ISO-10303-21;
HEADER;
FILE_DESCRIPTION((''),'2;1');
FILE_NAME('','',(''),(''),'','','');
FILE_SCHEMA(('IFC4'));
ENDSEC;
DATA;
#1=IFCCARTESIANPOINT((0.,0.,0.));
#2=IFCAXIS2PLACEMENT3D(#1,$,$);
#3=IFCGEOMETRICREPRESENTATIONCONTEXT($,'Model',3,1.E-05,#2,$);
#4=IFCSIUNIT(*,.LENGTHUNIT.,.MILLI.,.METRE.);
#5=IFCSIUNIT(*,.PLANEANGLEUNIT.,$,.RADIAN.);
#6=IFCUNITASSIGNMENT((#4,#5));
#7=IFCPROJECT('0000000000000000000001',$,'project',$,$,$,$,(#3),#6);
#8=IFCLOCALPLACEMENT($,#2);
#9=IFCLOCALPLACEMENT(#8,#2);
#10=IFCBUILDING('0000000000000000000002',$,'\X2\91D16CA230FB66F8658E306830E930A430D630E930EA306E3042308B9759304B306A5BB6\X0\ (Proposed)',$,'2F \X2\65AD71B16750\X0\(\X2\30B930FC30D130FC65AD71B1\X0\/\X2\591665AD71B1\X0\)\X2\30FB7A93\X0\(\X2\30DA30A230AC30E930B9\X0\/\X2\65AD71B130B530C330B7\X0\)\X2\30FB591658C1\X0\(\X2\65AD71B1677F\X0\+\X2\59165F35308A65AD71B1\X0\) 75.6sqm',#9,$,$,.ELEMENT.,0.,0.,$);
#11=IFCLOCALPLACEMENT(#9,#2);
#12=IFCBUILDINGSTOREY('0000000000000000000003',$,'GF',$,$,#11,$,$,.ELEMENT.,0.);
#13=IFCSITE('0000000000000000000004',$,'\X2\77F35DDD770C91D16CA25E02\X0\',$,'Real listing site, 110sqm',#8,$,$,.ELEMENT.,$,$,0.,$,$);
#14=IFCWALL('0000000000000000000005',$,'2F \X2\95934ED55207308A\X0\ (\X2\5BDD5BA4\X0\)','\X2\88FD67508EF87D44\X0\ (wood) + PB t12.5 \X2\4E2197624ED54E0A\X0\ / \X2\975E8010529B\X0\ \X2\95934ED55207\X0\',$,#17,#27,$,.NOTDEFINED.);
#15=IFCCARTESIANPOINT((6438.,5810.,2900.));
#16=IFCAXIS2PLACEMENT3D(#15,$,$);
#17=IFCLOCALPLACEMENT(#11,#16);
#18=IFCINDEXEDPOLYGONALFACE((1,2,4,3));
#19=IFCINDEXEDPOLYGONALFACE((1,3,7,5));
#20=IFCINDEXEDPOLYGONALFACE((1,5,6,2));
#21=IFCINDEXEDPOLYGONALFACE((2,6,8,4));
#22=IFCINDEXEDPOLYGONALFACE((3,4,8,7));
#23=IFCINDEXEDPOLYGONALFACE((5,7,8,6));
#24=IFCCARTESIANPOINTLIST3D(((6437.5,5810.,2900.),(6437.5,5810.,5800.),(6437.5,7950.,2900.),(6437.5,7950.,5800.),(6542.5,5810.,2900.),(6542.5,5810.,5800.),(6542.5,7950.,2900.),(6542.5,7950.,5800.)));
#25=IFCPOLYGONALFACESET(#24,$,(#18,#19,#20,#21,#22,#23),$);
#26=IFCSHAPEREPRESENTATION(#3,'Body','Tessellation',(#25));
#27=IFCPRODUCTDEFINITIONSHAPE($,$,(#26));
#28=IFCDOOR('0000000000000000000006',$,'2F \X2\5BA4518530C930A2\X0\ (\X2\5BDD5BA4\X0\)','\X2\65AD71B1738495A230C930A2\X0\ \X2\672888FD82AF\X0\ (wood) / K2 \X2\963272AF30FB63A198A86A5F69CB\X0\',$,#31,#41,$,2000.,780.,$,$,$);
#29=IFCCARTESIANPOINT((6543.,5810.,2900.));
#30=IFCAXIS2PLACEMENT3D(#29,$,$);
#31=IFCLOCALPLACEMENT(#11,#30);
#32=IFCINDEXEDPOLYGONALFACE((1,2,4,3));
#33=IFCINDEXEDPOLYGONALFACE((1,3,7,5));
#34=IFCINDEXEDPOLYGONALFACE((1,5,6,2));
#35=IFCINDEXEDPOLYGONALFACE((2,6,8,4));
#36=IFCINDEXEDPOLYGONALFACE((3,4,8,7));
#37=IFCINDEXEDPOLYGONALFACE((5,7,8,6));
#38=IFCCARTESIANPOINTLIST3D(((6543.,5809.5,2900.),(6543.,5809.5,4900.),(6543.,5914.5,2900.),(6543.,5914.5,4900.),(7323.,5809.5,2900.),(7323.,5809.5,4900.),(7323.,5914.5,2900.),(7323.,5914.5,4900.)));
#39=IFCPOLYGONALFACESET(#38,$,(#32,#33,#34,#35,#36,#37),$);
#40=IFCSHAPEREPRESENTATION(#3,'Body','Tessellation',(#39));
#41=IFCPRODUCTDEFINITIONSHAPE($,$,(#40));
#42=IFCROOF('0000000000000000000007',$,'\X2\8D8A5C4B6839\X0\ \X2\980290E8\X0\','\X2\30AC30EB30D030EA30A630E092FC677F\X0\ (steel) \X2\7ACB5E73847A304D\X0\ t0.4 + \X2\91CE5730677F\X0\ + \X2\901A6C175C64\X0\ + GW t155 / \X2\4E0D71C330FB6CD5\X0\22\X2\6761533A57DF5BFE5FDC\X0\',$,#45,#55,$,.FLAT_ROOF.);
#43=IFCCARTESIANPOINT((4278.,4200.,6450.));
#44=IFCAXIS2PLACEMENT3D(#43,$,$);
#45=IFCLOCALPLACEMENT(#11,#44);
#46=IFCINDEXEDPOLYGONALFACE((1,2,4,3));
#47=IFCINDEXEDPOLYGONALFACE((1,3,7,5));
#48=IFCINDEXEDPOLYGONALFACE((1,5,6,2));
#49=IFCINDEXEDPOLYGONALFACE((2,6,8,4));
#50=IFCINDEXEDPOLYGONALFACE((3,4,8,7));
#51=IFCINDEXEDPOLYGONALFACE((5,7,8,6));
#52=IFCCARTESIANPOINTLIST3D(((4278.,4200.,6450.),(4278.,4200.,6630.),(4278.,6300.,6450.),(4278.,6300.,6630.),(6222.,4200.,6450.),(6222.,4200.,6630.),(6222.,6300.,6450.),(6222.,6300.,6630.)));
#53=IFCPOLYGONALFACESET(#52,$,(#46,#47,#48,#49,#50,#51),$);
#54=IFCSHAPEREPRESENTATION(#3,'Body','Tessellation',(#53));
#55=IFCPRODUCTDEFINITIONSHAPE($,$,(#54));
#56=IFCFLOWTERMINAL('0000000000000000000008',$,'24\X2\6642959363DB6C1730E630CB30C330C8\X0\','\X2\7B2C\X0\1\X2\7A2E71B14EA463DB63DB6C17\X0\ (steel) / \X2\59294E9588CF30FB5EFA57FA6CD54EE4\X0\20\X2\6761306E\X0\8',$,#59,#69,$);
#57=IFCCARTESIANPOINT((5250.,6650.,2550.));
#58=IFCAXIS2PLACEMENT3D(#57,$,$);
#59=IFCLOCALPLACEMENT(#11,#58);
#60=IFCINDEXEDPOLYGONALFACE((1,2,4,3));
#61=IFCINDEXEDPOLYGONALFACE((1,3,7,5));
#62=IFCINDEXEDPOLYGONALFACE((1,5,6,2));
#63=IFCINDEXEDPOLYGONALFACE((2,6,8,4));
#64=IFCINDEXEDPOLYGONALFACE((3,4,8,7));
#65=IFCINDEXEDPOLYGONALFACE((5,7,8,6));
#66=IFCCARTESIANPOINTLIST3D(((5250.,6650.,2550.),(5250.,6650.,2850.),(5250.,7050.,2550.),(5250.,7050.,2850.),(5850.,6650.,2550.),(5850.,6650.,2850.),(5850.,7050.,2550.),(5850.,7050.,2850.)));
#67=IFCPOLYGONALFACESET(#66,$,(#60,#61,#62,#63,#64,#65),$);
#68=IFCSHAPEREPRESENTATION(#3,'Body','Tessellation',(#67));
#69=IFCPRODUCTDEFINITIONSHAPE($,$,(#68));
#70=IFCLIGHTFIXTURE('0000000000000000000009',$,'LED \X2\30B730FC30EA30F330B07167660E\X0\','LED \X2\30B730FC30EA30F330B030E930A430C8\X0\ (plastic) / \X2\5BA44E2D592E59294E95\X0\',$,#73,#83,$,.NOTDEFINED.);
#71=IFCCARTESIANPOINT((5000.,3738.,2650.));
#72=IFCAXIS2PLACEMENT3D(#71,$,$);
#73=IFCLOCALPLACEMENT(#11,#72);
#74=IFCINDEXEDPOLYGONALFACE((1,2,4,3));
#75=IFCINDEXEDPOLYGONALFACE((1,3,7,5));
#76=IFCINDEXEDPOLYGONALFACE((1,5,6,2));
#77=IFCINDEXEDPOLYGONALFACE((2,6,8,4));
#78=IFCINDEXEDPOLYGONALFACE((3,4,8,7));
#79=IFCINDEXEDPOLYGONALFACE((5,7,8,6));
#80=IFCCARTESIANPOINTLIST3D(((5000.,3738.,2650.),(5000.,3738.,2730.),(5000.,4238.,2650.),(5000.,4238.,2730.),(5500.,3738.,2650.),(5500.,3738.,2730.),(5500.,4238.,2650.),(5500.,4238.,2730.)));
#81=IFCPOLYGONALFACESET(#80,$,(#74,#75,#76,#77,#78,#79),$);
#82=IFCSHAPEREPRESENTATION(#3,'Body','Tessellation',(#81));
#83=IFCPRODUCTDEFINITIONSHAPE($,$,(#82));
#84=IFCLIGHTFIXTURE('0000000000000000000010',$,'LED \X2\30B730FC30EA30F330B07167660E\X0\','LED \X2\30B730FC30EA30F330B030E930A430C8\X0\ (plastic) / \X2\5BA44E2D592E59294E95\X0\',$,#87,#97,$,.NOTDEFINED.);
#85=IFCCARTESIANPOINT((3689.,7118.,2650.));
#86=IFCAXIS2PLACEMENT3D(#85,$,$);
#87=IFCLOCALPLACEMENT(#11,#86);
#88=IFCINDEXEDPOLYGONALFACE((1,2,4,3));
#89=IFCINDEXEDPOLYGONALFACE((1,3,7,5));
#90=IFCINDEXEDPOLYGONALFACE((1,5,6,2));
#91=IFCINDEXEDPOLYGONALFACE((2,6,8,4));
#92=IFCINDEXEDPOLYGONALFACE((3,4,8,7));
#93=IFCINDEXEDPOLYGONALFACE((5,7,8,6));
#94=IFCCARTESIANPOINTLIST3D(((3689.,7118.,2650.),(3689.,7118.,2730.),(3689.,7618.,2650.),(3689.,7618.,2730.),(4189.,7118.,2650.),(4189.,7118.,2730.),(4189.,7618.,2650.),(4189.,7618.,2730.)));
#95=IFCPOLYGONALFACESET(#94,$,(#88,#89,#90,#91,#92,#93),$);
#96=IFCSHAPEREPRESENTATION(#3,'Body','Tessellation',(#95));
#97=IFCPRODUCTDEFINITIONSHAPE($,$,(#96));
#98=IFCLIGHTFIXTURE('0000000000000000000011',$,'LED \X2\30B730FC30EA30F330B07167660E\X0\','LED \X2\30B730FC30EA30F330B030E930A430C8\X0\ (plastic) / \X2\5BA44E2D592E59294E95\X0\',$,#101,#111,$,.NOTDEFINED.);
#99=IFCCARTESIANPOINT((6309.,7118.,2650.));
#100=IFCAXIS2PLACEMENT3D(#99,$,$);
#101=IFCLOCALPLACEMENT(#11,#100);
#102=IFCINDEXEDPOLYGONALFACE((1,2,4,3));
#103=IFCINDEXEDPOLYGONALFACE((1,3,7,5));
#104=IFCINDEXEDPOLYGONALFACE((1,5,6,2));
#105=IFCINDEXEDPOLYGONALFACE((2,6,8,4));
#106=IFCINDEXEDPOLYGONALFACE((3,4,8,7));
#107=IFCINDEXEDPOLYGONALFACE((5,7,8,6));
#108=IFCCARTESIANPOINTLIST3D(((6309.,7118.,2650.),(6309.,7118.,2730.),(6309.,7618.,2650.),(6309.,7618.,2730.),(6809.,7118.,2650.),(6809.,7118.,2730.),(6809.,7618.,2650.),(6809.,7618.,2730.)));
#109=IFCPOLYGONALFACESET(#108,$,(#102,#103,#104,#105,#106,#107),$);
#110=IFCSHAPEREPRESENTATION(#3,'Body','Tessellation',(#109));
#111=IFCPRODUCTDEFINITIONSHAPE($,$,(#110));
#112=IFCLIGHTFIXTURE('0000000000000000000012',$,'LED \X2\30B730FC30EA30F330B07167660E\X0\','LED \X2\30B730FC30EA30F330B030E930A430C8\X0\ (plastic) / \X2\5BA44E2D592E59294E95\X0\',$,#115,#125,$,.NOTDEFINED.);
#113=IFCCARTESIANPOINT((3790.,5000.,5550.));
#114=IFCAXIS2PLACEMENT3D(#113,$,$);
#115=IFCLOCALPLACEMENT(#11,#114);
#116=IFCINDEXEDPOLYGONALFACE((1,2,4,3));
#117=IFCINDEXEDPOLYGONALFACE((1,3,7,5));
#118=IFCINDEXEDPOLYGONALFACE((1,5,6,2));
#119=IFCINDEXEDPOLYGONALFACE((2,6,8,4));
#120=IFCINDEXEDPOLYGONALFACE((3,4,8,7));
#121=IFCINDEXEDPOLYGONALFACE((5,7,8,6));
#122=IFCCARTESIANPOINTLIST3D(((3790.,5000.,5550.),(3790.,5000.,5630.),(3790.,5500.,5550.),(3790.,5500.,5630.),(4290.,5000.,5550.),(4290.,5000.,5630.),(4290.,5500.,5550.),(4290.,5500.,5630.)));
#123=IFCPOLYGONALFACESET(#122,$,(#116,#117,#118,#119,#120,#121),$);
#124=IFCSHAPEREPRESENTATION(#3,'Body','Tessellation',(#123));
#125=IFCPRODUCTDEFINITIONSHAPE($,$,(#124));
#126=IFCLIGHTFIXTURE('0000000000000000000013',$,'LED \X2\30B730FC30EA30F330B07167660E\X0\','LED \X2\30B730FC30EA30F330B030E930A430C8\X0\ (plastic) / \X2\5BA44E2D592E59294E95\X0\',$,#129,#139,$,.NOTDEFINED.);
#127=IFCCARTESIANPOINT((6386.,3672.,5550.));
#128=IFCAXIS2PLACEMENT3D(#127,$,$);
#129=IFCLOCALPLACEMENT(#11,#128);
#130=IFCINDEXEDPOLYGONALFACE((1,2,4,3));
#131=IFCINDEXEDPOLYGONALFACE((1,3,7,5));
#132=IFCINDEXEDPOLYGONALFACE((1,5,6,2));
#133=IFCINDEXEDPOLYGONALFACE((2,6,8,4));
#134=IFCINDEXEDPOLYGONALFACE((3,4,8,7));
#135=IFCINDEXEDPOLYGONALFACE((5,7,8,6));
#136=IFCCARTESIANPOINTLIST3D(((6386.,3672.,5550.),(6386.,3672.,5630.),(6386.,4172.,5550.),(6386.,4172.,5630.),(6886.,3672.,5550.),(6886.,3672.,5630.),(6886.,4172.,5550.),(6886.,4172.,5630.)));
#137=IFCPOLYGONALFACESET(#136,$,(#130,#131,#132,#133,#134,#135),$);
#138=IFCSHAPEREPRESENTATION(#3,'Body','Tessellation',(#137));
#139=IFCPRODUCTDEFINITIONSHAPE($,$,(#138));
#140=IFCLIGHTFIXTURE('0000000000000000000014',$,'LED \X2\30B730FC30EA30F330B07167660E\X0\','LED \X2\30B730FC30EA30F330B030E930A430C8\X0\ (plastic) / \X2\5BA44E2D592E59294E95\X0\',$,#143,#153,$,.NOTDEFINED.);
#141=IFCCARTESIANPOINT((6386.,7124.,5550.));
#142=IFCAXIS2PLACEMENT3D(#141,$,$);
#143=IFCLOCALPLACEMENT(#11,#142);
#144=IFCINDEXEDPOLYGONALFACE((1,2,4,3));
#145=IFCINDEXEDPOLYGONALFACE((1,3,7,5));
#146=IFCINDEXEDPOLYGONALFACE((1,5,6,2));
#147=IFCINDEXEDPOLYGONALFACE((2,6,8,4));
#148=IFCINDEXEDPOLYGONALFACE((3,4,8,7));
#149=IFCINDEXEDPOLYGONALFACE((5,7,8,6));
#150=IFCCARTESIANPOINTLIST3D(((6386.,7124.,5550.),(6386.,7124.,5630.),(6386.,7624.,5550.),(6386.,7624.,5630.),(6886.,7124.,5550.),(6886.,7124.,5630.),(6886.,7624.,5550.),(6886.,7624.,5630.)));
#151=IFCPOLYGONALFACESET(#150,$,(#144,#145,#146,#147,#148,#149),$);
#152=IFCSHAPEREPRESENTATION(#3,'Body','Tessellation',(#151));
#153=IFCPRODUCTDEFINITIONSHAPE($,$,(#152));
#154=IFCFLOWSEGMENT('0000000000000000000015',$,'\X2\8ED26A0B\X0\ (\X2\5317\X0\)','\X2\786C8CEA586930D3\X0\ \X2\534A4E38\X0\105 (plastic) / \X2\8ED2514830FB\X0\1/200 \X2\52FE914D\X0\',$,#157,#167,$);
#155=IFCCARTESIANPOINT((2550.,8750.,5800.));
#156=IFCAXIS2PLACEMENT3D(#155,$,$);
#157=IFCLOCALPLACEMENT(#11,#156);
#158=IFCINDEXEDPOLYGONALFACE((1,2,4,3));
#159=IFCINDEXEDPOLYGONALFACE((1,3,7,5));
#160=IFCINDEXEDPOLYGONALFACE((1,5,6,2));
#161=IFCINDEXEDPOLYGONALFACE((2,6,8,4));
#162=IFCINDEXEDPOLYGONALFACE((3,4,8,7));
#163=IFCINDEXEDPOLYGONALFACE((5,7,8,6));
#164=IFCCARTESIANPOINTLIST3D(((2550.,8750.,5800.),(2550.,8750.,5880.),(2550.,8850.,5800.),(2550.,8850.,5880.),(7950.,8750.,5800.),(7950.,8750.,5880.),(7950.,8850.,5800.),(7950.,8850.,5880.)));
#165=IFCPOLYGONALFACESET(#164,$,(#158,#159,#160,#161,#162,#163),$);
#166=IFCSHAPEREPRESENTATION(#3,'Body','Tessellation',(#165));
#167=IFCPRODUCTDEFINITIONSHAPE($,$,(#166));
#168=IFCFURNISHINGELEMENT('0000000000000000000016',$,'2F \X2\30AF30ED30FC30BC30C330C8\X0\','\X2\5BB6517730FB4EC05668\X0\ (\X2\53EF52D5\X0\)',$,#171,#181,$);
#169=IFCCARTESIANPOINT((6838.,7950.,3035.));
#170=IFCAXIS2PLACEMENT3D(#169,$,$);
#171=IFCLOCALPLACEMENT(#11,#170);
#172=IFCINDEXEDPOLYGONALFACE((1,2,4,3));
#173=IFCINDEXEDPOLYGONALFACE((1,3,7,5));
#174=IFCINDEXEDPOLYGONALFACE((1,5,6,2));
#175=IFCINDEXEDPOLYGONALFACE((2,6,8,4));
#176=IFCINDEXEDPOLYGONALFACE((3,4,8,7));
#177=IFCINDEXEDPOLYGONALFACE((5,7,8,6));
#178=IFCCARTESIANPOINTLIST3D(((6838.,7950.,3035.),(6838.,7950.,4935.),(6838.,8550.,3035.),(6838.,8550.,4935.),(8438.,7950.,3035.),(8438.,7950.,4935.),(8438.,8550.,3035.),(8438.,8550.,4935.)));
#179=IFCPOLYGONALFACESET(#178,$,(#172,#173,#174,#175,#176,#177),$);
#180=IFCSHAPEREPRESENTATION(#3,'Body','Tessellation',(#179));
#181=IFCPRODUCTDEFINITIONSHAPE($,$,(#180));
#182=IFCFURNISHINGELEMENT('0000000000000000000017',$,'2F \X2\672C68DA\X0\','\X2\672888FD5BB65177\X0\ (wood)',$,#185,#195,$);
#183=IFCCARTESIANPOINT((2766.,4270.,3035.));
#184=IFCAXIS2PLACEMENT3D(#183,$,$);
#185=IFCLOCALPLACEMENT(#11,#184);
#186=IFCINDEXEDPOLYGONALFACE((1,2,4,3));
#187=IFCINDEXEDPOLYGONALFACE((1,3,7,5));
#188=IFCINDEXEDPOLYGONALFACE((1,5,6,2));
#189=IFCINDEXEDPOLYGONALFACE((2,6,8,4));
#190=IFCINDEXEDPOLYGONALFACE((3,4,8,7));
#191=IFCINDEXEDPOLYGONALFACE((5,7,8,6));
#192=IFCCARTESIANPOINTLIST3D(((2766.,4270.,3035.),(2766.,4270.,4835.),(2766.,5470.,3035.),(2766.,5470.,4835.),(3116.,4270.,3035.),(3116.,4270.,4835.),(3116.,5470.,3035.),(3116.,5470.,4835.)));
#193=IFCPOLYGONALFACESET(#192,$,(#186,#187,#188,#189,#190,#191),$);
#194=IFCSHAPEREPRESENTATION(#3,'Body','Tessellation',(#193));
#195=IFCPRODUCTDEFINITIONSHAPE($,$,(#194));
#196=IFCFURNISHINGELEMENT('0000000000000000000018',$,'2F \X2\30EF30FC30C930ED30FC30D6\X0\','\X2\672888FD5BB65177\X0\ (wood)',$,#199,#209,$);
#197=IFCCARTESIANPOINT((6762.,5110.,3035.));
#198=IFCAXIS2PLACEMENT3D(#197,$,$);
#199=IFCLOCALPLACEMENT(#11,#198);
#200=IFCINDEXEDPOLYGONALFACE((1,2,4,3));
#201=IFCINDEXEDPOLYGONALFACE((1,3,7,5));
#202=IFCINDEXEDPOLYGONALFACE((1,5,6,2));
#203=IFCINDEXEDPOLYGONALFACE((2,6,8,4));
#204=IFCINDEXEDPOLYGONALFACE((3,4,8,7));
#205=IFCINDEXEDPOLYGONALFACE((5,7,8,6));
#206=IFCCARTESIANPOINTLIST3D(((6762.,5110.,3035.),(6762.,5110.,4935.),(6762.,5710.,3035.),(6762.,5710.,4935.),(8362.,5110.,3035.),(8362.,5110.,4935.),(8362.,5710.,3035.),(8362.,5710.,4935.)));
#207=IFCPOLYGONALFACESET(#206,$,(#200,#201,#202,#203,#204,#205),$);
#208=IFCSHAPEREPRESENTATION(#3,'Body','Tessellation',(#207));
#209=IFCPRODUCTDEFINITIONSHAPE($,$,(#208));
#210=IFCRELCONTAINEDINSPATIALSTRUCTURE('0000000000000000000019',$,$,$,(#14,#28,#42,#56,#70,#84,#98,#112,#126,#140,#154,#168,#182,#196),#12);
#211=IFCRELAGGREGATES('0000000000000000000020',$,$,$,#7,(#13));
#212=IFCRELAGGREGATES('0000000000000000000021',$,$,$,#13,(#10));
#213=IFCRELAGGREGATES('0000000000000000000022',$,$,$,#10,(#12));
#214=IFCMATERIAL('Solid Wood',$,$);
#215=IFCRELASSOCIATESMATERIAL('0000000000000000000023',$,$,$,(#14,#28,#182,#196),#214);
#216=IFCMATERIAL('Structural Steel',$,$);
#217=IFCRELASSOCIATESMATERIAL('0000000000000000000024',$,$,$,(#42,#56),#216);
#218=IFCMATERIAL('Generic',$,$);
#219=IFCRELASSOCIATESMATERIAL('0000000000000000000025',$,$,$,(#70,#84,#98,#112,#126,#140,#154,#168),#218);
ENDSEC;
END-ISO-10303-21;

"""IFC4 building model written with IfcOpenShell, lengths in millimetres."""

from ifc_helpers import new_model, si_unit, frame, frame_2d, origin, place, context, project, spatial, rectangle, extrude, material, element, save


model = new_model("IFC4")

# Units and contexts
model_context = context("Model", 3, precision=1e-05, world=origin())
ifc_project = project(units=[si_unit("LENGTHUNIT", "METRE", prefix="MILLI"), si_unit("PLANEANGLEUNIT", "RADIAN")], contexts=[model_context])

# Site, building, storey
site_placement = place(None, origin())
site = spatial("IfcSite", under=ifc_project, at=site_placement, Name="石川県金沢市", ObjectType="Real listing site, 110sqm", CompositionType="ELEMENT", RefElevation=0.0)
building_placement = place(site_placement, origin())
building = spatial("IfcBuilding", under=site, at=building_placement, Name="金沢・書斎とライブラリのある静かな家 (Proposed)", ObjectType="2F 断熱材(スーパー断熱/外断熱)・窓(ペアガラス/断熱サッシ)・外壁(断熱板+外張り断熱) 75.6sqm", CompositionType="ELEMENT", ElevationOfRefHeight=0.0, ElevationOfTerrain=0.0)
storey_placement = place(building_placement, origin())
storey = spatial("IfcBuildingStorey", under=building, at=storey_placement, Name="GF", CompositionType="ELEMENT", Elevation=0.0)

# Shared definitions
ifc_material_1 = material(Name="Solid Wood")

# Wall
wall_1_placement = place(storey_placement, frame((6438.0, 5810.0, 2900.0)))
element("IfcWall", 1, at=wall_1_placement, inside=storey, material=ifc_material_1, Name="2F 間仕切り (寝室)", Description="製材軸組 (wood) + PB t12.5 両面仕上 / 非耐力 間仕切", PredefinedType="NOTDEFINED", context=model_context, shape_type="SweptSolid", body=[
    extrude(rectangle(XDim=105.0, YDim=2140.0, at=frame_2d((52.0, 1070.0))), frame((6438.0, 5810.0, 2900.0)), (0.0, 0.0, 1.0), 2900.0),
])

# Door
door_placement = place(storey_placement, frame((6543.0, 5810.0, 2900.0)))
element("IfcDoor", 2, at=door_placement, inside=storey, material=ifc_material_1, Name="2F 室内ドア (寝室)", Description="断熱玄関ドア 木製芯 (wood) / K2 防犯・採風機構", OverallHeight=2000.0, OverallWidth=780.0, context=model_context, shape_type="SweptSolid", body=[
    extrude(rectangle(XDim=780.0, YDim=105.0, at=frame_2d((390.0, 52.0))), frame((6543.0, 5810.0, 2900.0)), (0.0, 0.0, 1.0), 2000.0),
])

# Roof
ifc_material_2 = material(Name="Structural Steel")
roof_placement = place(storey_placement, frame((4278.0, 4200.0, 6450.0)))
element("IfcRoof", 3, at=roof_placement, inside=storey, material=ifc_material_2, Name="越屋根 頂部", Description="ガルバリウム鋼板 (steel) 立平葺き t0.4 + 野地板 + 通気層 + GW t155 / 不燃・法22条区域対応", PredefinedType="FLAT_ROOF", context=model_context, shape_type="SweptSolid", body=[
    extrude(rectangle(XDim=1944.0, YDim=2100.0, at=frame_2d((972.0, 1050.0))), frame((4278.0, 4200.0, 6450.0)), (0.0, 0.0, 1.0), 180.0),
])

# Flow terminal
flow_terminal_placement = place(storey_placement, frame((5250.0, 6650.0, 2550.0)))
element("IfcFlowTerminal", 4, at=flow_terminal_placement, inside=storey, material=ifc_material_2, Name="24時間換気ユニット", Description="第1種熱交換換気 (steel) / 天井裏・建基法令20条の8", context=model_context, shape_type="SweptSolid", body=[
    extrude(rectangle(XDim=600.0, YDim=400.0, at=frame_2d((300.0, 200.0))), frame((5250.0, 6650.0, 2550.0)), (0.0, 0.0, 1.0), 300.0),
])

# Light fixtures
ifc_material_3 = material(Name="Generic")
light_fixture_1_placement = place(storey_placement, frame((5000.0, 3738.0, 2650.0)))
element("IfcLightFixture", 5, at=light_fixture_1_placement, inside=storey, material=ifc_material_3, Name="LED シーリング照明", Description="LED シーリングライト (plastic) / 室中央天井", PredefinedType="NOTDEFINED", context=model_context, shape_type="SweptSolid", body=[
    extrude(rectangle(XDim=500.0, YDim=500.0, at=frame_2d((250.0, 250.0))), frame((5000.0, 3738.0, 2650.0)), (0.0, 0.0, 1.0), 80.0),
])
light_fixture_2_placement = place(storey_placement, frame((3689.0, 7118.0, 2650.0)))
element("IfcLightFixture", 6, at=light_fixture_2_placement, inside=storey, material=ifc_material_3, Name="LED シーリング照明", Description="LED シーリングライト (plastic) / 室中央天井", PredefinedType="NOTDEFINED", context=model_context, shape_type="SweptSolid", body=[
    extrude(rectangle(XDim=500.0, YDim=500.0, at=frame_2d((250.0, 250.0))), frame((3689.0, 7118.0, 2650.0)), (0.0, 0.0, 1.0), 80.0),
])
light_fixture_3_placement = place(storey_placement, frame((6309.0, 7118.0, 2650.0)))
element("IfcLightFixture", 7, at=light_fixture_3_placement, inside=storey, material=ifc_material_3, Name="LED シーリング照明", Description="LED シーリングライト (plastic) / 室中央天井", PredefinedType="NOTDEFINED", context=model_context, shape_type="SweptSolid", body=[
    extrude(rectangle(XDim=500.0, YDim=500.0, at=frame_2d((250.0, 250.0))), frame((6309.0, 7118.0, 2650.0)), (0.0, 0.0, 1.0), 80.0),
])
light_fixture_4_placement = place(storey_placement, frame((3790.0, 5000.0, 5550.0)))
element("IfcLightFixture", 8, at=light_fixture_4_placement, inside=storey, material=ifc_material_3, Name="LED シーリング照明", Description="LED シーリングライト (plastic) / 室中央天井", PredefinedType="NOTDEFINED", context=model_context, shape_type="SweptSolid", body=[
    extrude(rectangle(XDim=500.0, YDim=500.0, at=frame_2d((250.0, 250.0))), frame((3790.0, 5000.0, 5550.0)), (0.0, 0.0, 1.0), 80.0),
])
light_fixture_5_placement = place(storey_placement, frame((6386.0, 3672.0, 5550.0)))
element("IfcLightFixture", 9, at=light_fixture_5_placement, inside=storey, material=ifc_material_3, Name="LED シーリング照明", Description="LED シーリングライト (plastic) / 室中央天井", PredefinedType="NOTDEFINED", context=model_context, shape_type="SweptSolid", body=[
    extrude(rectangle(XDim=500.0, YDim=500.0, at=frame_2d((250.0, 250.0))), frame((6386.0, 3672.0, 5550.0)), (0.0, 0.0, 1.0), 80.0),
])
light_fixture_6_placement = place(storey_placement, frame((6386.0, 7124.0, 5550.0)))
element("IfcLightFixture", 10, at=light_fixture_6_placement, inside=storey, material=ifc_material_3, Name="LED シーリング照明", Description="LED シーリングライト (plastic) / 室中央天井", PredefinedType="NOTDEFINED", context=model_context, shape_type="SweptSolid", body=[
    extrude(rectangle(XDim=500.0, YDim=500.0, at=frame_2d((250.0, 250.0))), frame((6386.0, 7124.0, 5550.0)), (0.0, 0.0, 1.0), 80.0),
])

# Flow segment
flow_segment_placement = place(storey_placement, frame((2550.0, 8750.0, 5800.0)))
element("IfcFlowSegment", 11, at=flow_segment_placement, inside=storey, material=ifc_material_3, Name="軒樋 (北)", Description="硬質塩ビ 半丸105 (plastic) / 軒先・1/200 勾配", context=model_context, shape_type="SweptSolid", body=[
    extrude(rectangle(XDim=5400.0, YDim=100.0, at=frame_2d((2700.0, 50.0))), frame((2550.0, 8750.0, 5800.0)), (0.0, 0.0, 1.0), 80.0),
])

# Furnishing elements
furnishing_1_placement = place(storey_placement, frame((6838.0, 7950.0, 3035.0)))
element("IfcFurnishingElement", 12, at=furnishing_1_placement, inside=storey, material=ifc_material_3, Name="2F クローゼット", Description="家具・什器 (可動)", context=model_context, shape_type="SweptSolid", body=[
    extrude(rectangle(XDim=1600.0, YDim=600.0, at=frame_2d((800.0, 300.0))), frame((6838.0, 7950.0, 3035.0)), (0.0, 0.0, 1.0), 1900.0),
])
furnishing_2_placement = place(storey_placement, frame((2766.0, 4270.0, 3035.0)))
element("IfcFurnishingElement", 13, at=furnishing_2_placement, inside=storey, material=ifc_material_1, Name="2F 本棚", Description="木製家具 (wood)", context=model_context, shape_type="SweptSolid", body=[
    extrude(rectangle(XDim=350.0, YDim=1200.0, at=frame_2d((175.0, 600.0))), frame((2766.0, 4270.0, 3035.0)), (0.0, 0.0, 1.0), 1800.0),
])
furnishing_3_placement = place(storey_placement, frame((6762.0, 5110.0, 3035.0)))
element("IfcFurnishingElement", 14, at=furnishing_3_placement, inside=storey, material=ifc_material_1, Name="2F ワードローブ", Description="木製家具 (wood)", context=model_context, shape_type="SweptSolid", body=[
    extrude(rectangle(XDim=1600.0, YDim=600.0, at=frame_2d((800.0, 300.0))), frame((6762.0, 5110.0, 3035.0)), (0.0, 0.0, 1.0), 1900.0),
])

save(model, "model.ifc")
